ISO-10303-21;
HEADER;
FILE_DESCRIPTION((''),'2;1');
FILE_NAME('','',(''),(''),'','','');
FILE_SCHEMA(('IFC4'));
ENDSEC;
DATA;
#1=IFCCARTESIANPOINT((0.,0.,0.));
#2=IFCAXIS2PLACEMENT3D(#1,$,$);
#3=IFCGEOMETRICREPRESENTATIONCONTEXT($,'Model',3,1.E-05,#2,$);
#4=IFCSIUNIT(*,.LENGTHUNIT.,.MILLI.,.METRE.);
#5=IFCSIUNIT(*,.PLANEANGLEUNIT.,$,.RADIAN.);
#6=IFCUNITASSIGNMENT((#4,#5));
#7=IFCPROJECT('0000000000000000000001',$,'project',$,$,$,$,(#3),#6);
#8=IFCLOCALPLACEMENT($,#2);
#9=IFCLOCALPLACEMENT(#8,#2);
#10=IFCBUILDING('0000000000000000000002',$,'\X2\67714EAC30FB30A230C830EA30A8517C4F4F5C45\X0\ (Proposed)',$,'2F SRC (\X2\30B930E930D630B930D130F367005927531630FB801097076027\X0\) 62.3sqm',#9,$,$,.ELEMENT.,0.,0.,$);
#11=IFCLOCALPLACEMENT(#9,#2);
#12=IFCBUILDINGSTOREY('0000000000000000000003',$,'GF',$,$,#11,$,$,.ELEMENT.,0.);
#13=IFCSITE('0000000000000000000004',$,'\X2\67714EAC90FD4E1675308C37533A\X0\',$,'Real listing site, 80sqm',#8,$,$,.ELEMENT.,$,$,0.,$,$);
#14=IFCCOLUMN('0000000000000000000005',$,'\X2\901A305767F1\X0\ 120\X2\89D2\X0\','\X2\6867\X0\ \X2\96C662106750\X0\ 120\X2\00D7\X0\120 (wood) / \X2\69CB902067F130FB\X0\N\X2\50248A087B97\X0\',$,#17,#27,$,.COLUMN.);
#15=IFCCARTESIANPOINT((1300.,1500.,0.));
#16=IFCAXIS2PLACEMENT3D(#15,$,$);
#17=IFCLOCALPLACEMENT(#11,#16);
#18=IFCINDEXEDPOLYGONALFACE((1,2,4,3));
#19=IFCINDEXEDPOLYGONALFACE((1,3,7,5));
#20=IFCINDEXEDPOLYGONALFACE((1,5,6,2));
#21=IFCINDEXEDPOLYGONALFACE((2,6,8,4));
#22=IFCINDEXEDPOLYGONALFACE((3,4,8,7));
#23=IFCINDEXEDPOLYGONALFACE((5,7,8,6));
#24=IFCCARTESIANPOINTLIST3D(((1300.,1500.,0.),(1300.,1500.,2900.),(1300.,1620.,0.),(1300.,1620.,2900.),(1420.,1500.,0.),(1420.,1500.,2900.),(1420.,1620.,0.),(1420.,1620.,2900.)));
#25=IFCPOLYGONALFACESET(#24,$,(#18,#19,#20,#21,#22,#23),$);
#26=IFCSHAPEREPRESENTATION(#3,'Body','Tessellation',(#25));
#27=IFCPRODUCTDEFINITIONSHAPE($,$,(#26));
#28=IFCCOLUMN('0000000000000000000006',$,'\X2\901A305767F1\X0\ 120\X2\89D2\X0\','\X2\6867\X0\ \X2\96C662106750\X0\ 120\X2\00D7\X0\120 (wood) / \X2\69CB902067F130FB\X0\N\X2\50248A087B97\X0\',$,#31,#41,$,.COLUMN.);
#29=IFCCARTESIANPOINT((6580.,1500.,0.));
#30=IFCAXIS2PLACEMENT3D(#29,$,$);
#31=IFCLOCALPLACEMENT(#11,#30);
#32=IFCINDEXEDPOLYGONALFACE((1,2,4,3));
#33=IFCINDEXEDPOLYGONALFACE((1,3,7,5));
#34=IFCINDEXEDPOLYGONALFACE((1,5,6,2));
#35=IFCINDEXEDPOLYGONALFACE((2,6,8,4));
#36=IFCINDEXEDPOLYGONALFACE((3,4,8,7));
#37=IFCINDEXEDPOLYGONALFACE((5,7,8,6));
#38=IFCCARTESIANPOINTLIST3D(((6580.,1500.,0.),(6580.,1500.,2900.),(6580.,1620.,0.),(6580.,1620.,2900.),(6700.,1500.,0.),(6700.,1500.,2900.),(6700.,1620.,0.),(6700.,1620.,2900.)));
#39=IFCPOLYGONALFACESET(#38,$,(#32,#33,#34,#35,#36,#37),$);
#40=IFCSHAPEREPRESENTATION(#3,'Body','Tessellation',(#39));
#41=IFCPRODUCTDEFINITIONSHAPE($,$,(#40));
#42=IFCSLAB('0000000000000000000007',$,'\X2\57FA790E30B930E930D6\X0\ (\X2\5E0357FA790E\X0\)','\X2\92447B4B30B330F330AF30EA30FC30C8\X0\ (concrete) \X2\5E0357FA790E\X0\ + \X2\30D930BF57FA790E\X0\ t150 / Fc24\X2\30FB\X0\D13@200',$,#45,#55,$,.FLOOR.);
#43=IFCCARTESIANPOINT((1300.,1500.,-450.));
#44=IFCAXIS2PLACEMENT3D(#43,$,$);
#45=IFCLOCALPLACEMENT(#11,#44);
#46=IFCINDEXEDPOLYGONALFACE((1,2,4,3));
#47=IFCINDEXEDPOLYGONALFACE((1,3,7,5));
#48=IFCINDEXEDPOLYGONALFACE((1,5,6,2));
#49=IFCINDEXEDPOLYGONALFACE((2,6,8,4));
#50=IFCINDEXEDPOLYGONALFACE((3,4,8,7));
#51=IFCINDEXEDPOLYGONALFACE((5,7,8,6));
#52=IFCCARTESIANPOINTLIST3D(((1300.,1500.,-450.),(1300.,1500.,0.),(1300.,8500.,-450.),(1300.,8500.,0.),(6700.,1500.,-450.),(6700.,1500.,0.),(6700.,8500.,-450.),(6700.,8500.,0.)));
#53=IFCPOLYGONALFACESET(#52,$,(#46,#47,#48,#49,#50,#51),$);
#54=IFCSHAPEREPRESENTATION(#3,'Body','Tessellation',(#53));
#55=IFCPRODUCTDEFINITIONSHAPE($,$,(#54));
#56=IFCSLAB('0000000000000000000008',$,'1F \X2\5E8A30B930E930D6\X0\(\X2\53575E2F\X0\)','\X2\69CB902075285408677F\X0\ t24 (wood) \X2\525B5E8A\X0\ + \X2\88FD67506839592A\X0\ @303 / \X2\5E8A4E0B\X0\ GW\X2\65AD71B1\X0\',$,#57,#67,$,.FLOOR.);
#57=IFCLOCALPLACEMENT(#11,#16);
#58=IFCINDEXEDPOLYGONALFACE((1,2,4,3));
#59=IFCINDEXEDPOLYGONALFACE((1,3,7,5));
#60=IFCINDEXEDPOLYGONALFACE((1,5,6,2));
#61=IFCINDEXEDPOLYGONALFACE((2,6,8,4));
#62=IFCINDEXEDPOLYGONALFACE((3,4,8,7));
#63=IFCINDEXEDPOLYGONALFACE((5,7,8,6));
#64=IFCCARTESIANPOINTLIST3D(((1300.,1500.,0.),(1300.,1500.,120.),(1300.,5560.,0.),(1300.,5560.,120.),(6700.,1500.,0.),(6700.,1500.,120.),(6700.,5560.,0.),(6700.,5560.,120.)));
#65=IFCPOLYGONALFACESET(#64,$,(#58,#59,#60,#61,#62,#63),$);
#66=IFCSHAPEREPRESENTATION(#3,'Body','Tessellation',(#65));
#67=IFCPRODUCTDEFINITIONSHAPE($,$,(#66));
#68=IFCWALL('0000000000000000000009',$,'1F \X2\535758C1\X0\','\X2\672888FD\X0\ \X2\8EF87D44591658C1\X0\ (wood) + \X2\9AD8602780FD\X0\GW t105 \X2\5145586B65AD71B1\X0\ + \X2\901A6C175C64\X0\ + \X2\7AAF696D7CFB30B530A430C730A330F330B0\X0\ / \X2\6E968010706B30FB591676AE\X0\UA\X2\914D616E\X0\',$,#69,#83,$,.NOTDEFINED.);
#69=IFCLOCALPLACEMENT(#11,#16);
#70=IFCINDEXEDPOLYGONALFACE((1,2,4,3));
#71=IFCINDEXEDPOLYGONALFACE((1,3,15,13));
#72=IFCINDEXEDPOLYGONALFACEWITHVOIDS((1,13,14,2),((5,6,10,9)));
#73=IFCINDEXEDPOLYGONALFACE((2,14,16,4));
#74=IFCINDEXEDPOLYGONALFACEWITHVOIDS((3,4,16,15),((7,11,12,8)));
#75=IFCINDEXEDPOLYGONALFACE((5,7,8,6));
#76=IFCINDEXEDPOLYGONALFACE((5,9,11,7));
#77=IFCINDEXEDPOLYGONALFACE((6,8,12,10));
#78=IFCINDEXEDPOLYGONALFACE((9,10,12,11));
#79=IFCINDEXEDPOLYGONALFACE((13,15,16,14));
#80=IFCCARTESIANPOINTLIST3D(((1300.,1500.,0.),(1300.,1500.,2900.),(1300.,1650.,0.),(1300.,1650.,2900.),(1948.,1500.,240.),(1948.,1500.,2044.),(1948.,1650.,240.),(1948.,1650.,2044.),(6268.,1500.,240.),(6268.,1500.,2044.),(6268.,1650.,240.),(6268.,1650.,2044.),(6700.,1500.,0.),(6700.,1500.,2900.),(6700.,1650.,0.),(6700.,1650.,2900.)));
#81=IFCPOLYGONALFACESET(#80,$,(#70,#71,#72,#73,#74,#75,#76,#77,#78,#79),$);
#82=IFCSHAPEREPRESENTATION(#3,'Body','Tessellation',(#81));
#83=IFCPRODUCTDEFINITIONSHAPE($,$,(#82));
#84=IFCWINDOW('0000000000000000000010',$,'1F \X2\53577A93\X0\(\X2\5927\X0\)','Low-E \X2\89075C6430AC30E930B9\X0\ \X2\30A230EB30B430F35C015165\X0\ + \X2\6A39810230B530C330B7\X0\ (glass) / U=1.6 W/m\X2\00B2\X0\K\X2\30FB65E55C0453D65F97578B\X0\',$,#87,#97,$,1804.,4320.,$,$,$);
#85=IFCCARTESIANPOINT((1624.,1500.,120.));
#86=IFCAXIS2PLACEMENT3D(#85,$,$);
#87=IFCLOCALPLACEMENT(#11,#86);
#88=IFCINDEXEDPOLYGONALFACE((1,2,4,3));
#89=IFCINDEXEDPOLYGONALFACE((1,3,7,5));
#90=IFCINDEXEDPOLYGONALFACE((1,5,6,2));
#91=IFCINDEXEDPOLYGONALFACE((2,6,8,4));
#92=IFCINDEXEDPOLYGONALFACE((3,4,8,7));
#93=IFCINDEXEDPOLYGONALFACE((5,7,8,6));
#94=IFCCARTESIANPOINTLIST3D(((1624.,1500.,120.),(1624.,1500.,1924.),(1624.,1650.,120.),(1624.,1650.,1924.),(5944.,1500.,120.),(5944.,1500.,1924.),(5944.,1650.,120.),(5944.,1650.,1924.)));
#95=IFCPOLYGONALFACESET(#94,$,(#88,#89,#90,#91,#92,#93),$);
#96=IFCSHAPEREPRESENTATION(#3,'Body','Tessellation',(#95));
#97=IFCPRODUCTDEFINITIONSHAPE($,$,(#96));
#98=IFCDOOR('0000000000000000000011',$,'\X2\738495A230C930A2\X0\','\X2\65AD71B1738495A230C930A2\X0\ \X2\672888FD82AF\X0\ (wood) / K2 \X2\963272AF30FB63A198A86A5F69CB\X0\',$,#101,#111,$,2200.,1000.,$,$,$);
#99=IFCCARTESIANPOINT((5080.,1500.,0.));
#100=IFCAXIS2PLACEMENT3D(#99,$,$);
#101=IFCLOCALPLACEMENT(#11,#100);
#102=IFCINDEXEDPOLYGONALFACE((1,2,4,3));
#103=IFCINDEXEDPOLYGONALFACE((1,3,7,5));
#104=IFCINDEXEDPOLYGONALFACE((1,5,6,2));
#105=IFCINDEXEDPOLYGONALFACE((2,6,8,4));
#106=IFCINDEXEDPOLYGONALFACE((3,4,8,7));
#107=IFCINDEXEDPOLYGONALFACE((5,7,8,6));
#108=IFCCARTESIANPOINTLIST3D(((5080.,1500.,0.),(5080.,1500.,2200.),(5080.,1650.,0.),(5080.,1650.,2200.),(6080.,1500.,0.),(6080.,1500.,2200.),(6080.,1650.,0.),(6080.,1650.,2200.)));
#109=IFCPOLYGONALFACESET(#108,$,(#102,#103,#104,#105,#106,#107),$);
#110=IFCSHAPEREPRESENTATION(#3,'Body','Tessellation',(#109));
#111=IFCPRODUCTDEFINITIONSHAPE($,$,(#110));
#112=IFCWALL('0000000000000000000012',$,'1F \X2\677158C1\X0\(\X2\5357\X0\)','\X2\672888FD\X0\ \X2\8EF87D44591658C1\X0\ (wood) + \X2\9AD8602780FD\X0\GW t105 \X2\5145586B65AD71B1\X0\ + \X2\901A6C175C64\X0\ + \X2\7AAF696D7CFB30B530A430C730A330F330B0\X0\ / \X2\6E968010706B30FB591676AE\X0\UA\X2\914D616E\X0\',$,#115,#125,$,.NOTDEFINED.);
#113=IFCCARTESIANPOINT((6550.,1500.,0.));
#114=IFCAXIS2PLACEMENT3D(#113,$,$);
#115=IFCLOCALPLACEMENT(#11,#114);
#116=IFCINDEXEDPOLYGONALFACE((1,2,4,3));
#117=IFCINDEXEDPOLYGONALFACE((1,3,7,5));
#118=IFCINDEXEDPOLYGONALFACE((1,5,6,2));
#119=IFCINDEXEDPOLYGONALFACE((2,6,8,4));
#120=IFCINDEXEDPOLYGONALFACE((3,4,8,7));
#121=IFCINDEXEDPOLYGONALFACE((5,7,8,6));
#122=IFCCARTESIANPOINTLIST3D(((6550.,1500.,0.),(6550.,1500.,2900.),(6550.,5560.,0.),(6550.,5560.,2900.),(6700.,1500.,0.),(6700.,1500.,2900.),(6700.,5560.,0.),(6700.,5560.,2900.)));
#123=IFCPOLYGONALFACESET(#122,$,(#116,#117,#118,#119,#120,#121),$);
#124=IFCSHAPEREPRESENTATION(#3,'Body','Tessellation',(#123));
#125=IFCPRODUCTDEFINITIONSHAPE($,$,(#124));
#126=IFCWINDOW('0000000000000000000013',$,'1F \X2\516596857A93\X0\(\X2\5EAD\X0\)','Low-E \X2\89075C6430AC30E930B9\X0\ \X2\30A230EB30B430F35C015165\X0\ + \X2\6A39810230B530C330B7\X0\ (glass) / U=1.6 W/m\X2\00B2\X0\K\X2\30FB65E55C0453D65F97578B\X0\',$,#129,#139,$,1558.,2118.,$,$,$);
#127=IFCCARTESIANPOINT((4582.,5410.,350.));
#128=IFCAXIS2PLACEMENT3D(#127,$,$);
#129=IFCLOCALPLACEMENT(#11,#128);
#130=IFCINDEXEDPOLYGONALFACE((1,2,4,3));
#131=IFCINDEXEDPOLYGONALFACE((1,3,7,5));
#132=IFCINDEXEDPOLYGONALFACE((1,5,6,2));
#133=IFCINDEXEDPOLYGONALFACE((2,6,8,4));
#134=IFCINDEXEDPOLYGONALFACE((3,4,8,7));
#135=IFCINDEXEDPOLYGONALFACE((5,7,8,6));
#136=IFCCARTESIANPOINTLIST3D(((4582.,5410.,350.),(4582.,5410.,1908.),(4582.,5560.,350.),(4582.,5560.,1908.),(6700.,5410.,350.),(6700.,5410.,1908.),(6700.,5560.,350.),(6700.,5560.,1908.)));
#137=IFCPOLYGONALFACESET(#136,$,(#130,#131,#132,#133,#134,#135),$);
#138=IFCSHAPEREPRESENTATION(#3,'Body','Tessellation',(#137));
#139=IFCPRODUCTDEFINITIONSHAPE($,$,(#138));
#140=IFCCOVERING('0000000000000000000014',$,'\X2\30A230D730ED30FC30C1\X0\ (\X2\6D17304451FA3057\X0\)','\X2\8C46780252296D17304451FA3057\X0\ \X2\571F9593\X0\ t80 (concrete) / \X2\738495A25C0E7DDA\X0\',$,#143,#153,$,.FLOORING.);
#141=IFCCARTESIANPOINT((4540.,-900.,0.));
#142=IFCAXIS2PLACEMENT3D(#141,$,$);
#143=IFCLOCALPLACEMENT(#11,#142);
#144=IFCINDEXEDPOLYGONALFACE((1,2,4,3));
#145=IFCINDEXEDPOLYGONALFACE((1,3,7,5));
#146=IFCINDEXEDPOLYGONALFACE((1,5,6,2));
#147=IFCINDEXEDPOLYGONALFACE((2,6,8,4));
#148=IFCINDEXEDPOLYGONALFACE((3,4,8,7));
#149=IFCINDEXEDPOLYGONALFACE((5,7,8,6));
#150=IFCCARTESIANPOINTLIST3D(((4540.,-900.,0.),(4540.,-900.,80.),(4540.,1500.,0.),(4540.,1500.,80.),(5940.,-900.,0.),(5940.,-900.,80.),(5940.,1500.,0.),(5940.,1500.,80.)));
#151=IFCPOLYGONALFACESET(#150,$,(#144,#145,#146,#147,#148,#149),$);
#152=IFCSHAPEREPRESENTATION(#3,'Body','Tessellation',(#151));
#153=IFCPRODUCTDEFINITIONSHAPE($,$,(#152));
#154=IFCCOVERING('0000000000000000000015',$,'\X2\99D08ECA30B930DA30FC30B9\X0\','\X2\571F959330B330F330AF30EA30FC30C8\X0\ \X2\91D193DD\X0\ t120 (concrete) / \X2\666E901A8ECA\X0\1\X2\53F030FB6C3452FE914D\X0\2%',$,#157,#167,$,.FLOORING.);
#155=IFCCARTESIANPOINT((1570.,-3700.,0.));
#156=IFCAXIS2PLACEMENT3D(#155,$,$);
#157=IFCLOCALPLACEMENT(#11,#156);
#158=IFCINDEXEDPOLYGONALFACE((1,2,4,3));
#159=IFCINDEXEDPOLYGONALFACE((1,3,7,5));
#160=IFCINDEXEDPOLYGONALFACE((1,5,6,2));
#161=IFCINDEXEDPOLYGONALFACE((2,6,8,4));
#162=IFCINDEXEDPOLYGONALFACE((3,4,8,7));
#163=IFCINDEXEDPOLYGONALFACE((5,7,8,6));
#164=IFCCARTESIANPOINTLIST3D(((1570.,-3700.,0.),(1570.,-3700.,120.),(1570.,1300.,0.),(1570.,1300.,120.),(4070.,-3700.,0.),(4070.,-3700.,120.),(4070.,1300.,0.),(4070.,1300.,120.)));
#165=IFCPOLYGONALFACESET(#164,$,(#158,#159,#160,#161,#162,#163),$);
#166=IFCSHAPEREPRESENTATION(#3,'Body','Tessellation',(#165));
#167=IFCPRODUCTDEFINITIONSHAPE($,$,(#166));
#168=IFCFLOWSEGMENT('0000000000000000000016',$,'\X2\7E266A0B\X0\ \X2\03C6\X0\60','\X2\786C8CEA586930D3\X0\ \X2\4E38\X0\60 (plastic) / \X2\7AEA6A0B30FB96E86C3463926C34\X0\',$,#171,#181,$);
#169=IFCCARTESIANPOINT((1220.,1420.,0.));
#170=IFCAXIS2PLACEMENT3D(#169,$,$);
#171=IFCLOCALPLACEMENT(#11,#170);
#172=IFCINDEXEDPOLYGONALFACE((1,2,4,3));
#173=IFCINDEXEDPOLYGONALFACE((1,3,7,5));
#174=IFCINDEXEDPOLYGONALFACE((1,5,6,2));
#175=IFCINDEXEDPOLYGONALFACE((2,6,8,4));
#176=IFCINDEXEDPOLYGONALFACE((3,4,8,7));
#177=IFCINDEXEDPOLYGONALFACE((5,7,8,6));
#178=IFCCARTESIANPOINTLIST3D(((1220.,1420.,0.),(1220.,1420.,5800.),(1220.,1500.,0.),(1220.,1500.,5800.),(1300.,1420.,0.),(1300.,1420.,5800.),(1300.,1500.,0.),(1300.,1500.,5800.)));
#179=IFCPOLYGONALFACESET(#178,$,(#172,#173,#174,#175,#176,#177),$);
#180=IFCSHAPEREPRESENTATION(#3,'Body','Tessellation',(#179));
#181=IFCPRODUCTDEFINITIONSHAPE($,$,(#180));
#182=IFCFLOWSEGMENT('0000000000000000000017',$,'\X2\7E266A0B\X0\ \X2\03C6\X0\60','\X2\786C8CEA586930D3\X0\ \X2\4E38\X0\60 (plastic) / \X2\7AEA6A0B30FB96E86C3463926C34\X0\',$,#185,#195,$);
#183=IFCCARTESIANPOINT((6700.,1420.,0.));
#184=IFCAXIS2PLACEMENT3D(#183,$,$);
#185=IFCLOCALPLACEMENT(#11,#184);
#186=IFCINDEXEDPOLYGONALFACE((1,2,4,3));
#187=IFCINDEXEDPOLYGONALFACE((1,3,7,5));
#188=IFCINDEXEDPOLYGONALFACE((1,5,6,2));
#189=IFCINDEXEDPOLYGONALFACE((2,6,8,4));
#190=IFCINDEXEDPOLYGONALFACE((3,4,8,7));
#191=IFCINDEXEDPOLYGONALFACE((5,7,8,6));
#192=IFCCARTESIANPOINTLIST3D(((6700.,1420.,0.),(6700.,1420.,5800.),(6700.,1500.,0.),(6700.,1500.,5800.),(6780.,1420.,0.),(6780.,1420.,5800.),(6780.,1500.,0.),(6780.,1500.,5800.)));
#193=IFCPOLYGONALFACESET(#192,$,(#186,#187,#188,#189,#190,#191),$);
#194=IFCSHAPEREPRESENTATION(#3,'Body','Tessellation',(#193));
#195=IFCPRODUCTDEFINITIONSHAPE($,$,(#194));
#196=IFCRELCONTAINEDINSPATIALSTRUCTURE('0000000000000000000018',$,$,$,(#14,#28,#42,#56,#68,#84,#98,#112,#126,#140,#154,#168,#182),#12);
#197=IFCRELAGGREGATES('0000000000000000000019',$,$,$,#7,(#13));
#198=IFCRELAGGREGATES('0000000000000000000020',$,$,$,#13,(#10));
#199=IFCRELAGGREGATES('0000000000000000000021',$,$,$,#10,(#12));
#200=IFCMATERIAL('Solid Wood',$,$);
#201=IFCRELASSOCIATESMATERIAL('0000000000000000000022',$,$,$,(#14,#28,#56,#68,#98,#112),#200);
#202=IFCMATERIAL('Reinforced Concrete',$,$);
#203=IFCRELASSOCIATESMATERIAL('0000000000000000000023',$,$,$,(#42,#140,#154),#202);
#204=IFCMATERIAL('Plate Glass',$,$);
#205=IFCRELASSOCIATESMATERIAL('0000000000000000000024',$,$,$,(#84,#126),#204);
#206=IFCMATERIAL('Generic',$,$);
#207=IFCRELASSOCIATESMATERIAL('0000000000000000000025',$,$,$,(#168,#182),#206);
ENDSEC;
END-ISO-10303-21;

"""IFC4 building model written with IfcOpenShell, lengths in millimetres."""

from ifc_helpers import new_model, si_unit, frame, frame_2d, origin, place, context, project, spatial, rectangle, extrude, material, element, fill, save


model = new_model("IFC4")

# Units and contexts
model_context = context("Model", 3, precision=1e-05, world=origin())
ifc_project = project(units=[si_unit("LENGTHUNIT", "METRE", prefix="MILLI"), si_unit("PLANEANGLEUNIT", "RADIAN")], contexts=[model_context])

# Site, building, storey
site_placement = place(None, origin())
site = spatial("IfcSite", under=ifc_project, at=site_placement, Name="東京都世田谷区", ObjectType="Real listing site, 80sqm", CompositionType="ELEMENT", RefElevation=0.0)
building_placement = place(site_placement, origin())
building = spatial("IfcBuilding", under=site, at=building_placement, Name="東京・アトリエ兼住居 (Proposed)", ObjectType="2F SRC (スラブスパン最大化・耐震性) 62.3sqm", CompositionType="ELEMENT", ElevationOfRefHeight=0.0, ElevationOfTerrain=0.0)
storey_placement = place(building_placement, origin())
storey = spatial("IfcBuildingStorey", under=building, at=storey_placement, Name="GF", CompositionType="ELEMENT", Elevation=0.0)

# Columns
ifc_material_1 = material(Name="Solid Wood")
column_1_placement = place(storey_placement, frame((1300.0, 1500.0, 0.0)))
element("IfcColumn", 1, at=column_1_placement, inside=storey, material=ifc_material_1, Name="通し柱 120角", Description="桧 集成材 120×120 (wood) / 構造柱・N値計算", PredefinedType="COLUMN", context=model_context, shape_type="SweptSolid", body=[
    extrude(rectangle(XDim=120.0, YDim=120.0, at=frame_2d((60.0, 60.0))), frame((1300.0, 1500.0, 0.0)), (0.0, 0.0, 1.0), 2900.0),
])
column_2_placement = place(storey_placement, frame((6580.0, 1500.0, 0.0)))
element("IfcColumn", 2, at=column_2_placement, inside=storey, material=ifc_material_1, Name="通し柱 120角", Description="桧 集成材 120×120 (wood) / 構造柱・N値計算", PredefinedType="COLUMN", context=model_context, shape_type="SweptSolid", body=[
    extrude(rectangle(XDim=120.0, YDim=120.0, at=frame_2d((60.0, 60.0))), frame((6580.0, 1500.0, 0.0)), (0.0, 0.0, 1.0), 2900.0),
])

# Slabs
ifc_material_2 = material(Name="Reinforced Concrete")
slab_1_placement = place(storey_placement, frame((1300.0, 1500.0, -450.0)))
element("IfcSlab", 3, at=slab_1_placement, inside=storey, material=ifc_material_2, Name="基礎スラブ (布基礎)", Description="鉄筋コンクリート (concrete) 布基礎 + ベタ基礎 t150 / Fc24・D13@200", PredefinedType="FLOOR", context=model_context, shape_type="SweptSolid", body=[
    extrude(rectangle(XDim=5400.0, YDim=7000.0, at=frame_2d((2700.0, 3500.0))), frame((1300.0, 1500.0, -450.0)), (0.0, 0.0, 1.0), 450.0),
])
slab_2_placement = place(storey_placement, frame((1300.0, 1500.0, 0.0)))
element("IfcSlab", 4, at=slab_2_placement, inside=storey, material=ifc_material_1, Name="1F 床スラブ(南帯)", Description="構造用合板 t24 (wood) 剛床 + 製材根太 @303 / 床下 GW断熱", PredefinedType="FLOOR", context=model_context, shape_type="SweptSolid", body=[
    extrude(rectangle(XDim=5400.0, YDim=4060.0, at=frame_2d((2700.0, 2030.0))), frame((1300.0, 1500.0, 0.0)), (0.0, 0.0, 1.0), 120.0),
])

# Wall, openings, window, door
wall_1_placement = place(storey_placement, frame((1300.0, 1500.0, 0.0)))
wall_1 = element("IfcWall", 5, at=wall_1_placement, inside=storey, material=ifc_material_1, Name="1F 南壁", Description="木製 軸組外壁 (wood) + 高性能GW t105 充填断熱 + 通気層 + 窯業系サイディング / 準耐火・外皮UA配慮", PredefinedType="NOTDEFINED", context=model_context, shape_type="SweptSolid", body=[
    extrude(rectangle(XDim=5400.0, YDim=150.0, at=frame_2d((2700.0, 75.0))), frame((1300.0, 1500.0, 0.0)), (0.0, 0.0, 1.0), 2900.0),
])
opening_1_placement = place(storey_placement, frame((1624.0, 1500.0, 120.0)))
opening_1 = element("IfcOpeningElement", 6, at=opening_1_placement, cuts=wall_1, PredefinedType="NOTDEFINED", context=model_context, shape_type="SweptSolid", body=[
    extrude(rectangle(XDim=4320.0, YDim=150.0, at=frame_2d((2160.0, 75.0))), frame((1624.0, 1500.0, 120.0)), (0.0, 0.0, 1.0), 1804.0),
])
opening_2_placement = place(storey_placement, frame((5080.0, 1500.0, 0.0)))
opening_2 = element("IfcOpeningElement", 7, at=opening_2_placement, cuts=wall_1, PredefinedType="NOTDEFINED", context=model_context, shape_type="SweptSolid", body=[
    extrude(rectangle(XDim=1000.0, YDim=150.0, at=frame_2d((500.0, 75.0))), frame((5080.0, 1500.0, 0.0)), (0.0, 0.0, 1.0), 2200.0),
])
ifc_material_3 = material(Name="Plate Glass")
window_1_placement = place(storey_placement, frame((1624.0, 1500.0, 120.0)))
window_1 = element("IfcWindow", 8, at=window_1_placement, inside=storey, material=ifc_material_3, Name="1F 南窓(大)", Description="Low-E 複層ガラス アルゴン封入 + 樹脂サッシ (glass) / U=1.6 W/m²K・日射取得型", OverallHeight=1804.0, OverallWidth=4320.0, context=model_context, shape_type="SweptSolid", body=[
    extrude(rectangle(XDim=4320.0, YDim=150.0, at=frame_2d((2160.0, 75.0))), frame((1624.0, 1500.0, 120.0)), (0.0, 0.0, 1.0), 1804.0),
])
fill(opening_1, window_1)
door_1_placement = place(storey_placement, frame((5080.0, 1500.0, 0.0)))
door_1 = element("IfcDoor", 9, at=door_1_placement, inside=storey, material=ifc_material_1, Name="玄関ドア", Description="断熱玄関ドア 木製芯 (wood) / K2 防犯・採風機構", OverallHeight=2200.0, OverallWidth=1000.0, context=model_context, shape_type="SweptSolid", body=[
    extrude(rectangle(XDim=1000.0, YDim=150.0, at=frame_2d((500.0, 75.0))), frame((5080.0, 1500.0, 0.0)), (0.0, 0.0, 1.0), 2200.0),
])
fill(opening_2, door_1)

# Wall, opening, window
wall_2_placement = place(storey_placement, frame((6550.0, 1500.0, 0.0)))
wall_2 = element("IfcWall", 10, at=wall_2_placement, inside=storey, material=ifc_material_1, Name="1F 東壁(南)", Description="木製 軸組外壁 (wood) + 高性能GW t105 充填断熱 + 通気層 + 窯業系サイディング / 準耐火・外皮UA配慮", PredefinedType="NOTDEFINED", context=model_context, shape_type="SweptSolid", body=[
    extrude(rectangle(XDim=150.0, YDim=4060.0, at=frame_2d((75.0, 2030.0))), frame((6550.0, 1500.0, 0.0)), (0.0, 0.0, 1.0), 2900.0),
])
opening_3_placement = place(storey_placement, frame((4582.0, 5410.0, 350.0)))
opening_3 = element("IfcOpeningElement", 11, at=opening_3_placement, cuts=wall_2, PredefinedType="NOTDEFINED", context=model_context, shape_type="SweptSolid", body=[
    extrude(rectangle(XDim=2118.0, YDim=150.0, at=frame_2d((1059.0, 75.0))), frame((4582.0, 5410.0, 350.0)), (0.0, 0.0, 1.0), 1558.0),
])
window_2_placement = place(storey_placement, frame((4582.0, 5410.0, 350.0)))
window_2 = element("IfcWindow", 12, at=window_2_placement, inside=storey, material=ifc_material_3, Name="1F 入隅窓(庭)", Description="Low-E 複層ガラス アルゴン封入 + 樹脂サッシ (glass) / U=1.6 W/m²K・日射取得型", OverallHeight=1558.0, OverallWidth=2118.0, context=model_context, shape_type="SweptSolid", body=[
    extrude(rectangle(XDim=2118.0, YDim=150.0, at=frame_2d((1059.0, 75.0))), frame((4582.0, 5410.0, 350.0)), (0.0, 0.0, 1.0), 1558.0),
])
fill(opening_3, window_2)

# Coverings
covering_1_placement = place(storey_placement, frame((4540.0, -900.0, 0.0)))
element("IfcCovering", 13, at=covering_1_placement, inside=storey, material=ifc_material_2, Name="アプローチ (洗い出し)", Description="豆砂利洗い出し 土間 t80 (concrete) / 玄関導線", PredefinedType="FLOORING", context=model_context, shape_type="SweptSolid", body=[
    extrude(rectangle(XDim=1400.0, YDim=2400.0, at=frame_2d((700.0, 1200.0))), frame((4540.0, -900.0, 0.0)), (0.0, 0.0, 1.0), 80.0),
])
covering_2_placement = place(storey_placement, frame((1570.0, -3700.0, 0.0)))
element("IfcCovering", 14, at=covering_2_placement, inside=storey, material=ifc_material_2, Name="駐車スペース", Description="土間コンクリート 金鏝 t120 (concrete) / 普通車1台・水勾配2%", PredefinedType="FLOORING", context=model_context, shape_type="SweptSolid", body=[
    extrude(rectangle(XDim=2500.0, YDim=5000.0, at=frame_2d((1250.0, 2500.0))), frame((1570.0, -3700.0, 0.0)), (0.0, 0.0, 1.0), 120.0),
])

# Flow segments
ifc_material_4 = material(Name="Generic")
flow_segment_1_placement = place(storey_placement, frame((1220.0, 1420.0, 0.0)))
element("IfcFlowSegment", 15, at=flow_segment_1_placement, inside=storey, material=ifc_material_4, Name="縦樋 φ60", Description="硬質塩ビ 丸60 (plastic) / 竪樋・雨水排水", context=model_context, shape_type="SweptSolid", body=[
    extrude(rectangle(XDim=80.0, YDim=80.0, at=frame_2d((40.0, 40.0))), frame((1220.0, 1420.0, 0.0)), (0.0, 0.0, 1.0), 5800.0),
])
flow_segment_2_placement = place(storey_placement, frame((6700.0, 1420.0, 0.0)))
element("IfcFlowSegment", 16, at=flow_segment_2_placement, inside=storey, material=ifc_material_4, Name="縦樋 φ60", Description="硬質塩ビ 丸60 (plastic) / 竪樋・雨水排水", context=model_context, shape_type="SweptSolid", body=[
    extrude(rectangle(XDim=80.0, YDim=80.0, at=frame_2d((40.0, 40.0))), frame((6700.0, 1420.0, 0.0)), (0.0, 0.0, 1.0), 5800.0),
])

save(model, "model.ifc")
